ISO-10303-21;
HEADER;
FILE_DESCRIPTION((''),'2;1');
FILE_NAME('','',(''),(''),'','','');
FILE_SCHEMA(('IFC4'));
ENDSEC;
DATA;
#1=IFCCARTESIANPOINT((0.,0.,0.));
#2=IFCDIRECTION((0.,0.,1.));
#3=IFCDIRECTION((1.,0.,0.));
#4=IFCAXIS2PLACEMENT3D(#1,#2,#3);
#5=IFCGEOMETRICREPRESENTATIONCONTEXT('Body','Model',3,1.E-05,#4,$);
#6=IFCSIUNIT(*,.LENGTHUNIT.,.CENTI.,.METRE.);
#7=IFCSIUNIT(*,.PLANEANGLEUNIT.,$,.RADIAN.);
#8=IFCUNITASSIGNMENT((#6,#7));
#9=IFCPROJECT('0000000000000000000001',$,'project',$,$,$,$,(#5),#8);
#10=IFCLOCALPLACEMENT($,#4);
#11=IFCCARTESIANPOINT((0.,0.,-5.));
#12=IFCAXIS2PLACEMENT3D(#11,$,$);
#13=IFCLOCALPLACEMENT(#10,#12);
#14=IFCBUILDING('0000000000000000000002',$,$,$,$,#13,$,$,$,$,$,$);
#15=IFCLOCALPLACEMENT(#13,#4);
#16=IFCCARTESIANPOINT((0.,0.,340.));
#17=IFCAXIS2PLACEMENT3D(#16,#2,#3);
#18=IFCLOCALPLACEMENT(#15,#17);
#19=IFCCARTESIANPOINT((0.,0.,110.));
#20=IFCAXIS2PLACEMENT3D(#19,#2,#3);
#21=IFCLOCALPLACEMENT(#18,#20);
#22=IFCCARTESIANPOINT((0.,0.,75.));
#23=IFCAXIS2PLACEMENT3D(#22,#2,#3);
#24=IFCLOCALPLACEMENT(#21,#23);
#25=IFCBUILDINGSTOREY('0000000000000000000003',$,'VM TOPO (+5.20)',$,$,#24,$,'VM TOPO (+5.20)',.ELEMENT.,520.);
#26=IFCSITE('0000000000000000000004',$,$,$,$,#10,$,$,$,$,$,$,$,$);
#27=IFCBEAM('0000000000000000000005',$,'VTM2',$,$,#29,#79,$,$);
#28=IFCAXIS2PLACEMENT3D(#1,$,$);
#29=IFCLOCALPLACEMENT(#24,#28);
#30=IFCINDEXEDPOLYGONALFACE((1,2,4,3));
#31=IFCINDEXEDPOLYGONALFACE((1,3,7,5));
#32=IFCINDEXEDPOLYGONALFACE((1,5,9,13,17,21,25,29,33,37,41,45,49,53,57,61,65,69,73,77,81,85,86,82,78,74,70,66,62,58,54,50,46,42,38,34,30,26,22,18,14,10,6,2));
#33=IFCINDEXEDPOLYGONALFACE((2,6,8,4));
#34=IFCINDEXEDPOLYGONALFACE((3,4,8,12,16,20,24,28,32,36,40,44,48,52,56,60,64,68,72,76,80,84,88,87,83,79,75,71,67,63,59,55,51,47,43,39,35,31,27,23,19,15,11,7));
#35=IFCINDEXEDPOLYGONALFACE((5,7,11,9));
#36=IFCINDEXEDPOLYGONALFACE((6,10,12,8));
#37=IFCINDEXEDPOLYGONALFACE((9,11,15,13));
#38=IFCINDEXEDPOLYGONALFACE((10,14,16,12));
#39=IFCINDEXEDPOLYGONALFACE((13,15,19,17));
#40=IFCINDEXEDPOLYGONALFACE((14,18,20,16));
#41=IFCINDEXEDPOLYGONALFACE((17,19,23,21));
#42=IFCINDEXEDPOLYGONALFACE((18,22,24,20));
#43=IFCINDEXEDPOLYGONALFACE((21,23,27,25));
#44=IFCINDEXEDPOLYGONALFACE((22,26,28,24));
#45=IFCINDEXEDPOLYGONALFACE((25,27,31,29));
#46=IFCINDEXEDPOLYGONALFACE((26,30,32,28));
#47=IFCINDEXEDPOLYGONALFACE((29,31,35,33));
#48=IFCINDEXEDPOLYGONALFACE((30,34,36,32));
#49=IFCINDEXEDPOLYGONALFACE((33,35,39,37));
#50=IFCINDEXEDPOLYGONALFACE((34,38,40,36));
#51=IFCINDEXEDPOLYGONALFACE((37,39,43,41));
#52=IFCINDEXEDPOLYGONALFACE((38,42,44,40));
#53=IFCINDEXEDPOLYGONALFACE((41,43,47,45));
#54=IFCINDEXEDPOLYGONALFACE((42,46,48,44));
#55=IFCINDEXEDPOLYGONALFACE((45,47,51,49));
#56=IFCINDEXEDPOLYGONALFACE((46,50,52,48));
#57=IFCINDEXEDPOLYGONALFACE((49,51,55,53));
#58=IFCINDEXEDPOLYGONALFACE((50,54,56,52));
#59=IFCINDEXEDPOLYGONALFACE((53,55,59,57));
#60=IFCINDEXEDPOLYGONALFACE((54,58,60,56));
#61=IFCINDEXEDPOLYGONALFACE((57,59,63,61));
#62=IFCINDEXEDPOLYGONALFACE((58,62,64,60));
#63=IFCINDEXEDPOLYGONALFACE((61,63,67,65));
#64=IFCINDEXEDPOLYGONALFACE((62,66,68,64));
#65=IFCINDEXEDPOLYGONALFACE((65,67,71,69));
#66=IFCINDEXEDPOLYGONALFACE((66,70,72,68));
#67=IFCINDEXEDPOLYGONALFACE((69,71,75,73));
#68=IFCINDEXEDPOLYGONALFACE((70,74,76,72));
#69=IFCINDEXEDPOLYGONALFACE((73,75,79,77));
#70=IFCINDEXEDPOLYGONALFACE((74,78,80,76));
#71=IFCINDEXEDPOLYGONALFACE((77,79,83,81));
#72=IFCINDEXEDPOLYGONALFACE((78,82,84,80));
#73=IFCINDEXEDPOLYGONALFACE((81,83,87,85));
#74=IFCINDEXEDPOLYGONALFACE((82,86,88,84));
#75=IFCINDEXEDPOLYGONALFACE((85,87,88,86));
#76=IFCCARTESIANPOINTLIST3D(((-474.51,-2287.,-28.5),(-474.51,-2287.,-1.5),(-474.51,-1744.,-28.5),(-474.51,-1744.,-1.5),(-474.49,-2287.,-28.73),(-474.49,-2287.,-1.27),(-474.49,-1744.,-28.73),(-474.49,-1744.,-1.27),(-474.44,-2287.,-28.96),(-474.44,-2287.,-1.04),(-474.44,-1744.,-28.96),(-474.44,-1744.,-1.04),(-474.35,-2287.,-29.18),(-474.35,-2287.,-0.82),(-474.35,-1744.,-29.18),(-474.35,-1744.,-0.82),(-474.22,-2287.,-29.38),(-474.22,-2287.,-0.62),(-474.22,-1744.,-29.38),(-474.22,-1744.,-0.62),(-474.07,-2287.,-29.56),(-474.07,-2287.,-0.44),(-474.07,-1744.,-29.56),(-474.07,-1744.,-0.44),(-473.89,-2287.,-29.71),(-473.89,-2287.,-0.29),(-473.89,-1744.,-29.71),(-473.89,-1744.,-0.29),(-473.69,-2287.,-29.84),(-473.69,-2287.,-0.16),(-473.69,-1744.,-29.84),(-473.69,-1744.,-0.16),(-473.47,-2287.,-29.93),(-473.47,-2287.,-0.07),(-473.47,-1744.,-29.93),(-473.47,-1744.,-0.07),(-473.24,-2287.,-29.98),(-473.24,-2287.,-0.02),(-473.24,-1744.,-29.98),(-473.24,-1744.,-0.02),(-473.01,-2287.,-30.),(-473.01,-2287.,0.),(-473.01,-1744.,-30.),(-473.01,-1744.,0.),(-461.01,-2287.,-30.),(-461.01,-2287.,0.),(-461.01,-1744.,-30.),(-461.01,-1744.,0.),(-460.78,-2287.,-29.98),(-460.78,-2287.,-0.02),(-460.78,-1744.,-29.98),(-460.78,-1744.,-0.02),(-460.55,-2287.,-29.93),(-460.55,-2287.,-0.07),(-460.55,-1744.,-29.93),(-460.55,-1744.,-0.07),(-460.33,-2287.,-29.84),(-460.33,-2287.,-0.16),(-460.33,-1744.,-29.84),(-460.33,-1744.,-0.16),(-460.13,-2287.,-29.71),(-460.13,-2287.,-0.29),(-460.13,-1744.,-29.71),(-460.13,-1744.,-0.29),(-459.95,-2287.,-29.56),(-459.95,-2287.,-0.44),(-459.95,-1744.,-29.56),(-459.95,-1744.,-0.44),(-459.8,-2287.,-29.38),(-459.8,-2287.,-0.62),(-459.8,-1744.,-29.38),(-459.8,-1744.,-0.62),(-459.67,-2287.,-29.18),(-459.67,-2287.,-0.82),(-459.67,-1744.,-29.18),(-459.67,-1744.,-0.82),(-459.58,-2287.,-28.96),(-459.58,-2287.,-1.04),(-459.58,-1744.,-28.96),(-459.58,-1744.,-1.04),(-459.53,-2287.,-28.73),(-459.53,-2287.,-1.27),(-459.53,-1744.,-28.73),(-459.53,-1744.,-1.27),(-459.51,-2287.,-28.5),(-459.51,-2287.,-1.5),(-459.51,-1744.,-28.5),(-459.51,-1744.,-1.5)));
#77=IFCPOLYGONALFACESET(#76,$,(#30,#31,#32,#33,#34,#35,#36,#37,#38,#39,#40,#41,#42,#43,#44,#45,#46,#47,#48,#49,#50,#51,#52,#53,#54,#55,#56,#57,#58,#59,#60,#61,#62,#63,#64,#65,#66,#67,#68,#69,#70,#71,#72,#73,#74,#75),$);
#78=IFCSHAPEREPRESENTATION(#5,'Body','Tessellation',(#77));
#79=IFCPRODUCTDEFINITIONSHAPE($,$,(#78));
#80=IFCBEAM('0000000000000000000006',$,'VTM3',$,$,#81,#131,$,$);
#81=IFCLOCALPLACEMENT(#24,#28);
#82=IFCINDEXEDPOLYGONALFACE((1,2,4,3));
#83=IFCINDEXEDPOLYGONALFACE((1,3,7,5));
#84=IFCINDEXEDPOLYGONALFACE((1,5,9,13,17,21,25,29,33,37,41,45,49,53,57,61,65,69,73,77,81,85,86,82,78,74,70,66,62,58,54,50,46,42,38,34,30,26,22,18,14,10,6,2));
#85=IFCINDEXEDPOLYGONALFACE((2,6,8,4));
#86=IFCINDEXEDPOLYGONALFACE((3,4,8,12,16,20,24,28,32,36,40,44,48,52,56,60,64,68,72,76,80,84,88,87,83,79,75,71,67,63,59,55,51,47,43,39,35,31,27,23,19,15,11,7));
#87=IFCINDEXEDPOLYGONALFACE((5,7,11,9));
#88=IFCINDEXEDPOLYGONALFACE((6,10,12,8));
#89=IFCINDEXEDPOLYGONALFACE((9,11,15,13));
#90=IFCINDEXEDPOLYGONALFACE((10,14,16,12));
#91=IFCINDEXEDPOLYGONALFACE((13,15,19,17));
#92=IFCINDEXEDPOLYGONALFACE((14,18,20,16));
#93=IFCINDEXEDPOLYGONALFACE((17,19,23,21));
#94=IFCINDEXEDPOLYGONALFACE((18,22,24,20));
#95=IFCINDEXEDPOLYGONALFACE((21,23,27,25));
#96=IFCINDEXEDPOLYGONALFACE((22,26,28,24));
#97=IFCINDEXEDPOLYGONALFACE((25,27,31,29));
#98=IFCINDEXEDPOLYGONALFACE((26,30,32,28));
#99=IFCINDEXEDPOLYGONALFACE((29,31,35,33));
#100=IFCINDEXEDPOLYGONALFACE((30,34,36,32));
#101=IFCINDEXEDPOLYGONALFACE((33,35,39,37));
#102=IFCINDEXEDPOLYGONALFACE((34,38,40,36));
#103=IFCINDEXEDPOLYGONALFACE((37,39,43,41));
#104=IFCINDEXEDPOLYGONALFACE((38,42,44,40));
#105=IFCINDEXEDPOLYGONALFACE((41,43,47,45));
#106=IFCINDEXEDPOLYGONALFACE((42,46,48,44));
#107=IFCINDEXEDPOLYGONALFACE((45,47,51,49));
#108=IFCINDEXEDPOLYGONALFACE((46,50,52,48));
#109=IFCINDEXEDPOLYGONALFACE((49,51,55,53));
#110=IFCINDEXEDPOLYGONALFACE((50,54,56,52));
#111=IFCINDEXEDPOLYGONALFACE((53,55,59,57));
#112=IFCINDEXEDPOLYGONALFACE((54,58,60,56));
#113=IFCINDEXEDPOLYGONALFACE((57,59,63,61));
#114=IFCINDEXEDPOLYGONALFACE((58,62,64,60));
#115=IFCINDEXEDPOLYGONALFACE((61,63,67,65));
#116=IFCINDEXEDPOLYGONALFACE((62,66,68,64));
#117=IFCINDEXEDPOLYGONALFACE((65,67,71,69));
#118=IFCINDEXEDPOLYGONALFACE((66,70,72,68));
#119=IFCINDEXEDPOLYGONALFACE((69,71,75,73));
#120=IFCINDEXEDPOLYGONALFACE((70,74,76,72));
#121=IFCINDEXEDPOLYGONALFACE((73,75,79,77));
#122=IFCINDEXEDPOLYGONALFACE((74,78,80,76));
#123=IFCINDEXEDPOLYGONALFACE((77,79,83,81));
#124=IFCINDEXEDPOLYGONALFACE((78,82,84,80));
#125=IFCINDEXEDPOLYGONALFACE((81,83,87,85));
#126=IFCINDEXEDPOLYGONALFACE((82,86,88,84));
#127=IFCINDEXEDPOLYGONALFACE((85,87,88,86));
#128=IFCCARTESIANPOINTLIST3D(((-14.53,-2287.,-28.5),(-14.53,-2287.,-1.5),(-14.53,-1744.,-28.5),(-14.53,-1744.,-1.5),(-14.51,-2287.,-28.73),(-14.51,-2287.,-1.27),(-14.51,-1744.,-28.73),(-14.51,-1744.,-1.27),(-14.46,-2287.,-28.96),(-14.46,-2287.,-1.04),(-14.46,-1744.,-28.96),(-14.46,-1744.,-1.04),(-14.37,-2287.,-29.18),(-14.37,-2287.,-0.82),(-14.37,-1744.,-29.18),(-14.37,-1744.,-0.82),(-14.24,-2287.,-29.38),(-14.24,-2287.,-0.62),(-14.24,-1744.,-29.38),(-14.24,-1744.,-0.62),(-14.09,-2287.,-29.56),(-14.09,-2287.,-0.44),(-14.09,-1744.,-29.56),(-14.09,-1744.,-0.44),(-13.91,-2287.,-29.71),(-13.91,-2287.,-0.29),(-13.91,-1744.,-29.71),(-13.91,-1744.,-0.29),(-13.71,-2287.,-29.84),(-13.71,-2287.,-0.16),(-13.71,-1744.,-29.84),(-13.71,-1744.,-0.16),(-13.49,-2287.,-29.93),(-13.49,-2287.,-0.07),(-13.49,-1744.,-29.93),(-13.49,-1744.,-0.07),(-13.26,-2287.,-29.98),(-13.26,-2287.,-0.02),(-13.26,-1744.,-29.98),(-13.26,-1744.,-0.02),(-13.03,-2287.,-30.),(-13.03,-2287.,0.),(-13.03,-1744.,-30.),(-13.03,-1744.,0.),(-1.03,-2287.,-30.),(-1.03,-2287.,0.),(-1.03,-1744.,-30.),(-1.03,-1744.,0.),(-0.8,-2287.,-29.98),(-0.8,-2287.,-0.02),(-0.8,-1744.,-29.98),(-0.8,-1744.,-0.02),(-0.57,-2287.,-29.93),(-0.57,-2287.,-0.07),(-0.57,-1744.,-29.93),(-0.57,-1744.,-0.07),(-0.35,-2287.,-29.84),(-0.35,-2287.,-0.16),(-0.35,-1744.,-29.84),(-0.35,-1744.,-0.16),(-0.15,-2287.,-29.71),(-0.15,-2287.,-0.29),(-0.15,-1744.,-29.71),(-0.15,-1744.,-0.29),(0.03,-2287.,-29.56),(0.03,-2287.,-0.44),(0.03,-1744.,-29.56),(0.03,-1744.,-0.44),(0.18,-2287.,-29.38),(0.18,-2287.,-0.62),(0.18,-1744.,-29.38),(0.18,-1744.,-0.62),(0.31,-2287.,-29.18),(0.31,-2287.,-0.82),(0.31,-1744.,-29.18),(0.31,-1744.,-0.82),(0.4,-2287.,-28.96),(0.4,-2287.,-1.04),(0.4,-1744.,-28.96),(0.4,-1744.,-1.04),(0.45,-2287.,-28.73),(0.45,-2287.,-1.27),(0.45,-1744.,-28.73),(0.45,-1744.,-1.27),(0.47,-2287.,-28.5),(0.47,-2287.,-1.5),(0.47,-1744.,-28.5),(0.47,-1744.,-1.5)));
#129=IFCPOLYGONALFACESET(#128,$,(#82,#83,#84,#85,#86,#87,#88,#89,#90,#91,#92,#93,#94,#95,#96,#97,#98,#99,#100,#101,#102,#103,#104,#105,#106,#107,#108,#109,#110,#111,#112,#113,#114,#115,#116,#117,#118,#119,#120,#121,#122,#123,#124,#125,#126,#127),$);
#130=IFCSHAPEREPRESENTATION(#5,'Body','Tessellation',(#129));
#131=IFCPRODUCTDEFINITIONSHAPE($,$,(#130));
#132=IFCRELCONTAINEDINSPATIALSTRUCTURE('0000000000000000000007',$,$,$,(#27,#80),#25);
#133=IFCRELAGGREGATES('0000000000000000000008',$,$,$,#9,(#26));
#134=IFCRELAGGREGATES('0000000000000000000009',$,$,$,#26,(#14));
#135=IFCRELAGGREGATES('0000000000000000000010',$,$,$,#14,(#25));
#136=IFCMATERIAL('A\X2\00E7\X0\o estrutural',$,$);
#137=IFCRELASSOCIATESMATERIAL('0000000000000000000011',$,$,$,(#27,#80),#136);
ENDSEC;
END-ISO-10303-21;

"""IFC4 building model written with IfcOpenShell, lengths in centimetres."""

from ifc_helpers import new_model, si_unit, frame, origin_with_axes, place, context, project, spatial, polyline, outline, extrude, material, element, save


model = new_model("IFC4")

# Units and contexts
model_context = context("Model", 3, precision=1e-05, world=origin_with_axes(), identifier="Body")
ifc_project = project(units=[si_unit("LENGTHUNIT", "METRE", prefix="CENTI"), si_unit("PLANEANGLEUNIT", "RADIAN")], contexts=[model_context])

# Site, building, storey
site_placement = place(None, origin_with_axes())
site = spatial("IfcSite", under=ifc_project, at=site_placement)
building_placement = place(site_placement, frame((0.0, 0.0, -5.0)))
building = spatial("IfcBuilding", under=site, at=building_placement)
placement_1 = place(building_placement, origin_with_axes())
placement_2 = place(placement_1, frame((0.0, 0.0, 340.0), z_axis=(0.0, 0.0, 1.0), x_axis=(1.0, 0.0, 0.0)))
placement_3 = place(placement_2, frame((0.0, 0.0, 110.0), z_axis=(0.0, 0.0, 1.0), x_axis=(1.0, 0.0, 0.0)))
storey_placement = place(placement_3, frame((0.0, 0.0, 75.0), z_axis=(0.0, 0.0, 1.0), x_axis=(1.0, 0.0, 0.0)))
storey = spatial("IfcBuildingStorey", under=building, at=storey_placement, Name="VM TOPO (+5.20)", LongName="VM TOPO (+5.20)", CompositionType="ELEMENT", Elevation=520.0)

# Beams
ifc_material_1 = material(Name="Aço estrutural")
beam_1_placement = place(storey_placement, frame((-467.01, -2015.5, 0.0), z_axis=(0.0, 0.0, 1.0), x_axis=(1.0, 0.0, 0.0)))
element("IfcBeam", 1, at=beam_1_placement, inside=storey, material=ifc_material_1, Name="VTM2", context=model_context, shape_type="SolidModel", body=[
    extrude(outline(polyline([(6.0, -15.0), (6.23, -14.98), (6.46, -14.93), (6.68, -14.84), (6.88, -14.71), (7.06, -14.56), (7.21, -14.38), (7.34, -14.18), (7.43, -13.96), (7.48, -13.73), (7.5, -13.5), (7.5, 13.5), (7.48, 13.73), (7.43, 13.96), (7.34, 14.18), (7.21, 14.38), (7.06, 14.56), (6.88, 14.71), (6.68, 14.84), (6.46, 14.93), (6.23, 14.98), (6.0, 15.0), (-6.0, 15.0), (-6.23, 14.98), (-6.46, 14.93), (-6.68, 14.84), (-6.88, 14.71), (-7.06, 14.56), (-7.21, 14.38), (-7.34, 14.18), (-7.43, 13.96), (-7.48, 13.73), (-7.5, 13.5), (-7.5, -13.5), (-7.48, -13.73), (-7.43, -13.96), (-7.34, -14.18), (-7.21, -14.38), (-7.06, -14.56), (-6.88, -14.71), (-6.68, -14.84), (-6.46, -14.93), (-6.23, -14.98), (-6.0, -15.0), (6.0, -15.0)])), frame((0.0, -271.5, -15.0), z_axis=(0.0, 1.0, 0.0), x_axis=(1.0, 0.0, 0.0)), (0.0, 0.0, 1.0), 543.0),
])
beam_2_placement = place(storey_placement, frame((-7.03, -2015.5, 0.0), z_axis=(0.0, 0.0, 1.0), x_axis=(1.0, 0.0, 0.0)))
element("IfcBeam", 2, at=beam_2_placement, inside=storey, material=ifc_material_1, Name="VTM3", context=model_context, shape_type="SolidModel", body=[
    extrude(outline(polyline([(6.0, -15.0), (6.23, -14.98), (6.46, -14.93), (6.68, -14.84), (6.88, -14.71), (7.06, -14.56), (7.21, -14.38), (7.34, -14.18), (7.43, -13.96), (7.48, -13.73), (7.5, -13.5), (7.5, 13.5), (7.48, 13.73), (7.43, 13.96), (7.34, 14.18), (7.21, 14.38), (7.06, 14.56), (6.88, 14.71), (6.68, 14.84), (6.46, 14.93), (6.23, 14.98), (6.0, 15.0), (-6.0, 15.0), (-6.23, 14.98), (-6.46, 14.93), (-6.68, 14.84), (-6.88, 14.71), (-7.06, 14.56), (-7.21, 14.38), (-7.34, 14.18), (-7.43, 13.96), (-7.48, 13.73), (-7.5, 13.5), (-7.5, -13.5), (-7.48, -13.73), (-7.43, -13.96), (-7.34, -14.18), (-7.21, -14.38), (-7.06, -14.56), (-6.88, -14.71), (-6.68, -14.84), (-6.46, -14.93), (-6.23, -14.98), (-6.0, -15.0), (6.0, -15.0)])), frame((0.0, -271.5, -15.0), z_axis=(0.0, 1.0, 0.0), x_axis=(1.0, 0.0, 0.0)), (0.0, 0.0, 1.0), 543.0),
])

save(model, "model.ifc")
